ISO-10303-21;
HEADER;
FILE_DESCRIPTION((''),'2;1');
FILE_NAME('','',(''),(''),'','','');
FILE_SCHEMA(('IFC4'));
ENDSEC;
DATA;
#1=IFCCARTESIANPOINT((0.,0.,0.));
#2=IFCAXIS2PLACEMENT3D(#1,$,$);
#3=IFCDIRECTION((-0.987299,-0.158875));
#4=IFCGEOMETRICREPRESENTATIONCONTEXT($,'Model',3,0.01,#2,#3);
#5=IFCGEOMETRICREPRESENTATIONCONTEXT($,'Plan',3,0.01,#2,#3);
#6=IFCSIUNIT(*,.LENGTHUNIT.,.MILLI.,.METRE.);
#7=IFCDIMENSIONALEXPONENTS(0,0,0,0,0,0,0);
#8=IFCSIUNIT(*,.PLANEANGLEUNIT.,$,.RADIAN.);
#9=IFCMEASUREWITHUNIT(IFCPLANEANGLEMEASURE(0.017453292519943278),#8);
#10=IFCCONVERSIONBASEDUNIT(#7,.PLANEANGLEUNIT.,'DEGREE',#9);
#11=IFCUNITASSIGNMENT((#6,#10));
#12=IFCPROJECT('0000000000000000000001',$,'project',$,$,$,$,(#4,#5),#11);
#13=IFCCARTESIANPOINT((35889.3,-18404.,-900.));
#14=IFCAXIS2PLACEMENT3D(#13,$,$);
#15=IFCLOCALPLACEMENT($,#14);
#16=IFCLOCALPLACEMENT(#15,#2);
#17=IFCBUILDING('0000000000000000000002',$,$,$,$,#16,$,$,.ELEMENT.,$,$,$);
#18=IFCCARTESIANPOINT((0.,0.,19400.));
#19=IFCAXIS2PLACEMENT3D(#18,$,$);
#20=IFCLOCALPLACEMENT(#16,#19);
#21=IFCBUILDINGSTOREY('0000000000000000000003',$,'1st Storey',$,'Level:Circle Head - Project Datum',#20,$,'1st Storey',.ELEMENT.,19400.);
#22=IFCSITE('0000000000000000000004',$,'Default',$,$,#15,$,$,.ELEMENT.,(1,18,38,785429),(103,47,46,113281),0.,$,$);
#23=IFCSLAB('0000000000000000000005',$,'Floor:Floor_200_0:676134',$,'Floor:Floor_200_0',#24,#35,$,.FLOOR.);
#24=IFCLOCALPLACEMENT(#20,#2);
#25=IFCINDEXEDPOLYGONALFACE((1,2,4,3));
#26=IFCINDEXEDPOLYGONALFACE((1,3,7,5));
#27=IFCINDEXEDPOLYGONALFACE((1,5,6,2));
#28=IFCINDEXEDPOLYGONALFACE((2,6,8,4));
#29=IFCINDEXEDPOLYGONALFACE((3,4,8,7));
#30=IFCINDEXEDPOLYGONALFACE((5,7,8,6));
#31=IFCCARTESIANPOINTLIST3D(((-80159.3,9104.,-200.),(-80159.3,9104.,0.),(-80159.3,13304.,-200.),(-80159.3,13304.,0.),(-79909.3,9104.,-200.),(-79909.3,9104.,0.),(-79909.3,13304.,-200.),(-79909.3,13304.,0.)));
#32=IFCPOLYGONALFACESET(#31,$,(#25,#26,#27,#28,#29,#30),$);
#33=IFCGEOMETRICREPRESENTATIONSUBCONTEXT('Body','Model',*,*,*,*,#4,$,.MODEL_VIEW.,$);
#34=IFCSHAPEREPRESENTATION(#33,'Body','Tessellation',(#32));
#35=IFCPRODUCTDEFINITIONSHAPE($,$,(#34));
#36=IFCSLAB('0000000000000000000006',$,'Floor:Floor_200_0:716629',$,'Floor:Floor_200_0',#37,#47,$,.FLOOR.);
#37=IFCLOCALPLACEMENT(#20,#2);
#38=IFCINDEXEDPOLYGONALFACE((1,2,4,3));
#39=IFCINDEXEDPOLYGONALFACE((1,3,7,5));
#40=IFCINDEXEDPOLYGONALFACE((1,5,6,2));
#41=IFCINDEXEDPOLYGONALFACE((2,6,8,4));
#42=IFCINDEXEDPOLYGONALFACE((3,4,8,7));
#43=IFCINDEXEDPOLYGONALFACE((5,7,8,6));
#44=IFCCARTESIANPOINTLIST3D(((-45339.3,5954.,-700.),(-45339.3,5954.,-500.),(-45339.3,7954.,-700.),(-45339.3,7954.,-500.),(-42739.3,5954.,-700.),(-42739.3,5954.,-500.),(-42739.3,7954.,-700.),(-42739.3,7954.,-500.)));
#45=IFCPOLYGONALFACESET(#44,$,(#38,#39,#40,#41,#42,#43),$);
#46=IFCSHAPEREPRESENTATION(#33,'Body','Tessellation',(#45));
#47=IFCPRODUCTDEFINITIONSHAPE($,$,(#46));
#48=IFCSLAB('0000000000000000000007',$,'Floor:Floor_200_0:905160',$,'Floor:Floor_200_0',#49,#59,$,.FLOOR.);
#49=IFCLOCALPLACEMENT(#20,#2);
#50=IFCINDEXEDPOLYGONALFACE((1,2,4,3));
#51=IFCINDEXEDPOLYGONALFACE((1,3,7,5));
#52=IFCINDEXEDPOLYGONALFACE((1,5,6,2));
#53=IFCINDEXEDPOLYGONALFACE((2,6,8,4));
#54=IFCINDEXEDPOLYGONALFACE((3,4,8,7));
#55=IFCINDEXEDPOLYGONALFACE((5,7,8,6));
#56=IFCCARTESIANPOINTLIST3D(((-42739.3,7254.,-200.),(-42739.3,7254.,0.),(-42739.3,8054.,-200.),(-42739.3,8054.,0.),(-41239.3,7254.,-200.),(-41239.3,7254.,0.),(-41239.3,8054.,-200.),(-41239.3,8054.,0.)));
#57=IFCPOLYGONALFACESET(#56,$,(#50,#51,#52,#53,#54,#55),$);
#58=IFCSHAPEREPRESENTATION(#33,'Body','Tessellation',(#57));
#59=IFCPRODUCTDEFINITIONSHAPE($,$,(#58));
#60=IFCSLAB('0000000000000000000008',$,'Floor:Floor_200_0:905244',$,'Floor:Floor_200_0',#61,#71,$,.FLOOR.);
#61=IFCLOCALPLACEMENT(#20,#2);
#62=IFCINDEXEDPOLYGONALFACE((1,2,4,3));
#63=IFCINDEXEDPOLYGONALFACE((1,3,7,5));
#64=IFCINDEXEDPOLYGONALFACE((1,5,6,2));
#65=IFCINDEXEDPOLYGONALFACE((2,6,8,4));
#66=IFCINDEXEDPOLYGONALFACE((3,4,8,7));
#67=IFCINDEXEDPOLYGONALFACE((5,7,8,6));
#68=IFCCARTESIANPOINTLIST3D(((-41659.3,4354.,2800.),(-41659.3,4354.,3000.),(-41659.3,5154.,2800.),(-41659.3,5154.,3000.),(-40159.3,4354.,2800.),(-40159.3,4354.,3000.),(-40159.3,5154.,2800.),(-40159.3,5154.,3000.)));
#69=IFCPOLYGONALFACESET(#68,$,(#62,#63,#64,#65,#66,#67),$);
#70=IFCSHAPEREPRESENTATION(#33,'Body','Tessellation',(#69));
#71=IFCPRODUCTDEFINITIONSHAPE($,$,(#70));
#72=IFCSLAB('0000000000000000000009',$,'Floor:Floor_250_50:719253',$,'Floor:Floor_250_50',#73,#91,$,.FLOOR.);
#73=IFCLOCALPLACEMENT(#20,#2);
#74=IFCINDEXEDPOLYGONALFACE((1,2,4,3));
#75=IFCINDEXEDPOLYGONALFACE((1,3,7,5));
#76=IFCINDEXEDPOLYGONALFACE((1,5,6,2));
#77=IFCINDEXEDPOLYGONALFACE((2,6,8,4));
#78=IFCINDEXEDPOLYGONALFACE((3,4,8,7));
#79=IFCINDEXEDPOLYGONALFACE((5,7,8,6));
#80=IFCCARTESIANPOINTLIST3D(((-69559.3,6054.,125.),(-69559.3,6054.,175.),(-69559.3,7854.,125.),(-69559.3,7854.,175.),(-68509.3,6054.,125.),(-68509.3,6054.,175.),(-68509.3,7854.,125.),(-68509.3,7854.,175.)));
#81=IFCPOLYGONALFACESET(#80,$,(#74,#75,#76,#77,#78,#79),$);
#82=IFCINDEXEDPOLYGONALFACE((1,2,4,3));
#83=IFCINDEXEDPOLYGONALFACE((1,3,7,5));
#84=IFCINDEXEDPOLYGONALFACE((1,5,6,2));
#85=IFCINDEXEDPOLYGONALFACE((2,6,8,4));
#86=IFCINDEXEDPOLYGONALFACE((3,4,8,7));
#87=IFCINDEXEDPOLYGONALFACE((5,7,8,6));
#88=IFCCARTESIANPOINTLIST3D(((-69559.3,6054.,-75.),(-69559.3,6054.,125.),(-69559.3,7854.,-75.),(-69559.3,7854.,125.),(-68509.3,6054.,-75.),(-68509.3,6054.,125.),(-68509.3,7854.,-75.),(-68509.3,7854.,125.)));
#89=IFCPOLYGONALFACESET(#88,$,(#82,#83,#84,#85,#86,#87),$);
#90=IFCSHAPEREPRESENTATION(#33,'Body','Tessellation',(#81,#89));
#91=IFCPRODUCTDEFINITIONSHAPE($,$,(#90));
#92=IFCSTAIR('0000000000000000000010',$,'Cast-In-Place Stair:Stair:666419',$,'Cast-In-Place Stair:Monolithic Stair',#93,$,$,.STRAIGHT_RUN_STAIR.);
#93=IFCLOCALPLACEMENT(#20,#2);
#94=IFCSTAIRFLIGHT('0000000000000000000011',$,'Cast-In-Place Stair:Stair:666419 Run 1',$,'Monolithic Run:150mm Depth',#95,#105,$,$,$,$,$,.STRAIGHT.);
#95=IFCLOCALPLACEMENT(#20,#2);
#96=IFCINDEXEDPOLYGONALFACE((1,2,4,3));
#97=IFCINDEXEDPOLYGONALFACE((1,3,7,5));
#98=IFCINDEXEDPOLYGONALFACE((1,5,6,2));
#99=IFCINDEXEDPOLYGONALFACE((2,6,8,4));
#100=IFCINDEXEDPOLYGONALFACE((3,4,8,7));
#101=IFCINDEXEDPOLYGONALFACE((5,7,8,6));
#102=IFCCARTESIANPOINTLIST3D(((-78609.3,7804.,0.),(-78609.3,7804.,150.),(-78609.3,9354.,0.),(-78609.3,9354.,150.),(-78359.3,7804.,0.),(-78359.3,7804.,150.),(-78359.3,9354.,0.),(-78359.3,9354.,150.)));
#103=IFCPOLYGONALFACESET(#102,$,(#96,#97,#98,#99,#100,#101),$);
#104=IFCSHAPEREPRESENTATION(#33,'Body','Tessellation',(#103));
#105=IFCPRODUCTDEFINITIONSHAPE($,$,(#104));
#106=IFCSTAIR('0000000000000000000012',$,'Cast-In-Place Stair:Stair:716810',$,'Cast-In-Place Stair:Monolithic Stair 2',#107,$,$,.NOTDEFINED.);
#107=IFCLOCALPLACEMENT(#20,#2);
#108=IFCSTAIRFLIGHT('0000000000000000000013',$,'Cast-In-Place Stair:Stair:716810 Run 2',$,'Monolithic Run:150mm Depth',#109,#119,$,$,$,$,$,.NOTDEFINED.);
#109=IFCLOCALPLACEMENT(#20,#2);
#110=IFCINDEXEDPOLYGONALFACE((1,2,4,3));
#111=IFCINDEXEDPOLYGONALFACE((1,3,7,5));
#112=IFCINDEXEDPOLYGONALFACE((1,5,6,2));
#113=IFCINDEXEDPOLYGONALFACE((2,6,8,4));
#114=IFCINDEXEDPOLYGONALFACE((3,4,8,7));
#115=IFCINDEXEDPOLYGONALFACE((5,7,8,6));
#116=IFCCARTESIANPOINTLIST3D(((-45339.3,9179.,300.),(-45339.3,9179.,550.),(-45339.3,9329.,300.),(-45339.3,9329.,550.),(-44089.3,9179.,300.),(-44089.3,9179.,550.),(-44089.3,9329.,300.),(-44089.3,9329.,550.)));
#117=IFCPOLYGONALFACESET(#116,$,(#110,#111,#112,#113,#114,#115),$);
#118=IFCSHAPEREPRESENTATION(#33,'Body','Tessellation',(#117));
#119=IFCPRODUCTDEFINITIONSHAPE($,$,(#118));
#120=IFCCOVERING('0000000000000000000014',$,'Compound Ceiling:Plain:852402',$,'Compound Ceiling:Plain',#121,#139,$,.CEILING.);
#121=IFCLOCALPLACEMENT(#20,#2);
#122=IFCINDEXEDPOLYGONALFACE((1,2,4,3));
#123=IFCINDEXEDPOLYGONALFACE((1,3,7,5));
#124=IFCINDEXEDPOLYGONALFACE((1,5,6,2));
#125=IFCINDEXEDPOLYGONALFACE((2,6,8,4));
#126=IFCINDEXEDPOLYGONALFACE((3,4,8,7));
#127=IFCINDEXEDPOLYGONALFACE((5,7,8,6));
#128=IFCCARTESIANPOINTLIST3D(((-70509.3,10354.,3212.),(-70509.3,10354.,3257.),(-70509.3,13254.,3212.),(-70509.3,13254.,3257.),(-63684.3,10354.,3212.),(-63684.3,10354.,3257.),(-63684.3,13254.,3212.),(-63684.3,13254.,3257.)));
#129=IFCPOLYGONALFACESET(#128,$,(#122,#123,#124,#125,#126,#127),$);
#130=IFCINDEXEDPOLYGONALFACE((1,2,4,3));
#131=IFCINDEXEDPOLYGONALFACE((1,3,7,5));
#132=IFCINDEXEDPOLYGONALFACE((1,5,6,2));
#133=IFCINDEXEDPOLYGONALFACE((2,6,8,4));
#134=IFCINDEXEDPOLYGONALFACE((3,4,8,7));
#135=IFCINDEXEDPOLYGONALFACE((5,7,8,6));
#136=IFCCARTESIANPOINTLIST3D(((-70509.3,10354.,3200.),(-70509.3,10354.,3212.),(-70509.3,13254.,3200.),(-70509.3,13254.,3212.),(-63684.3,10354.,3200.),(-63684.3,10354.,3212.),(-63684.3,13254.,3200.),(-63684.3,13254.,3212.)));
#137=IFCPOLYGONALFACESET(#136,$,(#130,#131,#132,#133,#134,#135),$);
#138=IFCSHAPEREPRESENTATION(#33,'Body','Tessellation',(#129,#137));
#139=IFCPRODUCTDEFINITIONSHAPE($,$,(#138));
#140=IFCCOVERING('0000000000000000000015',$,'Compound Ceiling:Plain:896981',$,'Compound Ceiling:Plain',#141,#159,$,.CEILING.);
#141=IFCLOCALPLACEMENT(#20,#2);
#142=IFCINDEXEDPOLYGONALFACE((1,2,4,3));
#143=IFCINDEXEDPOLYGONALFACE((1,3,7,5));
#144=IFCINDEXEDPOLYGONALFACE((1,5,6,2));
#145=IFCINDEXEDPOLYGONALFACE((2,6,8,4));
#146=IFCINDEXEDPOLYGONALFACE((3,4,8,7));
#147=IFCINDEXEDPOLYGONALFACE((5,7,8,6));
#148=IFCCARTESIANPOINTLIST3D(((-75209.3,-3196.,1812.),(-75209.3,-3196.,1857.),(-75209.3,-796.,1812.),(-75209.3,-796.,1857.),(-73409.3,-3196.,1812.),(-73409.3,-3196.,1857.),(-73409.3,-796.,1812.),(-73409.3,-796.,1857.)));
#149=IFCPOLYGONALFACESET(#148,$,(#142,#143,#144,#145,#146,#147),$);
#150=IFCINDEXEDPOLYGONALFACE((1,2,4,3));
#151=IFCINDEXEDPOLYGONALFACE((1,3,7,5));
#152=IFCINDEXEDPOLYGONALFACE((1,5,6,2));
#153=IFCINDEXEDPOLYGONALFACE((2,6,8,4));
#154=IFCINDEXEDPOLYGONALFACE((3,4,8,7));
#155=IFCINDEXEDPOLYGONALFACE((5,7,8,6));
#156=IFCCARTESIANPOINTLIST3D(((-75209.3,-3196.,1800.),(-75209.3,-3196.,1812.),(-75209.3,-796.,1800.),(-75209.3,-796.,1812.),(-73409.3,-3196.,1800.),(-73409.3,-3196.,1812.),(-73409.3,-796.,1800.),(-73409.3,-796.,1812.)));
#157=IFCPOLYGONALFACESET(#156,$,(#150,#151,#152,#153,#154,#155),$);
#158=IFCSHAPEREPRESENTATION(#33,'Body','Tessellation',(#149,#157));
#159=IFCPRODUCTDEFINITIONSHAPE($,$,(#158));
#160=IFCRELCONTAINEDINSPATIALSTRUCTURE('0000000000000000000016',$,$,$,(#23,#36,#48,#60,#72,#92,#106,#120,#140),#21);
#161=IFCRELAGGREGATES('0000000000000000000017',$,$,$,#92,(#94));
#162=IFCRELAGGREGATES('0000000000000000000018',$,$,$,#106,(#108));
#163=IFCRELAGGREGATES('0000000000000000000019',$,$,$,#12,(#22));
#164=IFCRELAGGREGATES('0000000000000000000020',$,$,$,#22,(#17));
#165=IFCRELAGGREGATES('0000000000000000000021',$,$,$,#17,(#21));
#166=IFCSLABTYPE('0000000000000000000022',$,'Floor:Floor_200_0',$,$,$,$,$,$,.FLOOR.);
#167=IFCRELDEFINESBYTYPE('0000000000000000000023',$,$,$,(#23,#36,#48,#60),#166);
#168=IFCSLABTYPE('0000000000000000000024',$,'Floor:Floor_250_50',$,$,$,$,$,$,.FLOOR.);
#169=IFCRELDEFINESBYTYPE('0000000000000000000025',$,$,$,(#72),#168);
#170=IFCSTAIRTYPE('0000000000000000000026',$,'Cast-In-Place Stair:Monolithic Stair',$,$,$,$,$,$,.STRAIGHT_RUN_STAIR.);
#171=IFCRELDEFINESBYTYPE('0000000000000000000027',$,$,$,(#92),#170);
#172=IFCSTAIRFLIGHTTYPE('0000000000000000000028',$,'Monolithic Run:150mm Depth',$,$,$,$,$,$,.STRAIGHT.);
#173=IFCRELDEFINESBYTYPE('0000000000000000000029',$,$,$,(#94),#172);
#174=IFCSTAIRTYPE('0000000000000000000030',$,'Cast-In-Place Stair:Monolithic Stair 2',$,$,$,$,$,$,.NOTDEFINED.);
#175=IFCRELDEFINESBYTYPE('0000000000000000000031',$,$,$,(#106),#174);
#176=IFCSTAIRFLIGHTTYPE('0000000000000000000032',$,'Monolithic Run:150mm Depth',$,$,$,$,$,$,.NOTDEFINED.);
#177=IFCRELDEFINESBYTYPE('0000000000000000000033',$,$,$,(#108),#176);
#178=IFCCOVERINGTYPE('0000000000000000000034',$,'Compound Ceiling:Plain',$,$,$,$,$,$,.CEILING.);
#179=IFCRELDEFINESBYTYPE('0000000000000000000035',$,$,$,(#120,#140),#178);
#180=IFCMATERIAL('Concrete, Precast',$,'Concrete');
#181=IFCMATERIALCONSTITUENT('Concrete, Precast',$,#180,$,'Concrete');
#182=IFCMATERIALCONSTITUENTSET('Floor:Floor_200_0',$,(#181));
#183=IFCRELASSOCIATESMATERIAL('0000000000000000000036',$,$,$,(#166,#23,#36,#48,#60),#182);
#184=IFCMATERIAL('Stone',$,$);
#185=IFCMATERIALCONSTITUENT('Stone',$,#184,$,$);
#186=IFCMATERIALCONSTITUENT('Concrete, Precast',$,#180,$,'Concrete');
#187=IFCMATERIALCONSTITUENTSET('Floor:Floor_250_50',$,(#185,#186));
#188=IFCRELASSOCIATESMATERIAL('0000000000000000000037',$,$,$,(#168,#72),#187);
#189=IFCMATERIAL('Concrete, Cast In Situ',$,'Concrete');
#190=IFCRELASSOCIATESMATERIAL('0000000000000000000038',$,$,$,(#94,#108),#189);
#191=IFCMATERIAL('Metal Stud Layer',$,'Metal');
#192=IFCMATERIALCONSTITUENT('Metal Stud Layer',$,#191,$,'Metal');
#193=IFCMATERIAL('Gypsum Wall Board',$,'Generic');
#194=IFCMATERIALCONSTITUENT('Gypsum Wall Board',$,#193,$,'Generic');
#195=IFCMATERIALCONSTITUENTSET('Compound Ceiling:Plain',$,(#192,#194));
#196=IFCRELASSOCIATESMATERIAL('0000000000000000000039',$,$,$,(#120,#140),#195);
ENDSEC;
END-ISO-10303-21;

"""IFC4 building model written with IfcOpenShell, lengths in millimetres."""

from ifc_helpers import new_model, entity, si_unit, converted_unit, direction, frame, origin, place, context, subcontext, project, spatial, indexed_curve, outline, extrude, material, constituent, constituent_set, type_object, element, aggregate, save


model = new_model("IFC4")

# Units and contexts
model_context = context("Model", 3, precision=0.01, world=origin(), true_north=direction((-0.987299, -0.158875)))
plan_context = context("Plan", 3, precision=0.01, world=origin(), true_north=direction((-0.987299, -0.158875)))
body_context = subcontext(model_context, "Body", "Model", "MODEL_VIEW")
ifc_project = project(units=[si_unit("LENGTHUNIT", "METRE", prefix="MILLI"), converted_unit("PLANEANGLEUNIT", "DEGREE", entity("IfcPlaneAngleMeasure", 0.017453292519943278), si_unit("PLANEANGLEUNIT", "RADIAN"), dimensions=[0, 0, 0, 0, 0, 0, 0])], contexts=[model_context, plan_context])

# Site, building, storey
site_placement = place(None, frame((35889.3, -18404.0, -900.0)))
site = spatial("IfcSite", under=ifc_project, at=site_placement, Name="Default", CompositionType="ELEMENT", RefLatitude=(1, 18, 38, 785429), RefLongitude=(103, 47, 46, 113281), RefElevation=0.0)
building_placement = place(site_placement, origin())
building = spatial("IfcBuilding", under=site, at=building_placement, CompositionType="ELEMENT")
storey_placement = place(building_placement, frame((0.0, 0.0, 19400.0)))
storey = spatial("IfcBuildingStorey", under=building, at=storey_placement, Name="1st Storey", ObjectType="Level:Circle Head - Project Datum", LongName="1st Storey", CompositionType="ELEMENT", Elevation=19400.0)

# Slabs
ifc_material_1 = material(Name="Concrete, Precast", Category="Concrete")
ifc_constituent_1 = constituent(ifc_material_1, Name="Concrete, Precast", Category="Concrete")
ifc_constituent_set_1 = constituent_set(constituents=[ifc_constituent_1], Name="Floor:Floor_200_0")
slab_type_1 = type_object("IfcSlabType", Name="Floor:Floor_200_0", PredefinedType="FLOOR", material=ifc_constituent_set_1)
slab_1_placement = place(storey_placement, origin())
element("IfcSlab", 1, at=slab_1_placement, inside=storey, type_object=slab_type_1, material=ifc_constituent_set_1, Name="Floor:Floor_200_0:676134", ObjectType="Floor:Floor_200_0", PredefinedType="FLOOR", context=body_context, shape_type="SweptSolid", body=[
    extrude(outline(indexed_curve([(-2100.0, -125.0), (2100.0, -125.0), (2100.0, 125.0), (-2100.0, 125.0), (-2100.0, -125.0)], self_intersect=False)), frame((-80034.3, 11204.0, 0.0), z_axis=(0.0, 0.0, -1.0), x_axis=(0.0, 1.0, 0.0)), (0.0, 0.0, 1.0), 200.0),
])
slab_2_placement = place(storey_placement, origin())
element("IfcSlab", 2, at=slab_2_placement, inside=storey, type_object=slab_type_1, material=ifc_constituent_set_1, Name="Floor:Floor_200_0:716629", ObjectType="Floor:Floor_200_0", PredefinedType="FLOOR", context=body_context, shape_type="SweptSolid", body=[
    extrude(outline(indexed_curve([(-1000.0, -1300.0), (1000.0, -1300.0), (1000.0, 1300.0), (-1000.0, 1300.0), (-1000.0, -1300.0)], self_intersect=False)), frame((-44039.3, 6954.0, -500.0), z_axis=(0.0, 0.0, -1.0), x_axis=(0.0, 1.0, 0.0)), (0.0, 0.0, 1.0), 200.0),
])
slab_3_placement = place(storey_placement, origin())
element("IfcSlab", 3, at=slab_3_placement, inside=storey, type_object=slab_type_1, material=ifc_constituent_set_1, Name="Floor:Floor_200_0:905160", ObjectType="Floor:Floor_200_0", PredefinedType="FLOOR", context=body_context, shape_type="SweptSolid", body=[
    extrude(outline(indexed_curve([(-400.0, -750.0), (400.0, -750.0), (400.0, 750.0), (-400.0, 750.0), (-400.0, -750.0)], self_intersect=False)), frame((-41989.3, 7654.0, 0.0), z_axis=(0.0, 0.0, -1.0), x_axis=(0.0, 1.0, 0.0)), (0.0, 0.0, 1.0), 200.0),
])
slab_4_placement = place(storey_placement, origin())
element("IfcSlab", 4, at=slab_4_placement, inside=storey, type_object=slab_type_1, material=ifc_constituent_set_1, Name="Floor:Floor_200_0:905244", ObjectType="Floor:Floor_200_0", PredefinedType="FLOOR", context=body_context, shape_type="SweptSolid", body=[
    extrude(outline(indexed_curve([(-400.0, -750.0), (400.0, -750.0), (400.0, 750.0), (-400.0, 750.0), (-400.0, -750.0)], self_intersect=False)), frame((-40909.3, 4754.0, 3000.0), z_axis=(0.0, 0.0, -1.0), x_axis=(0.0, 1.0, 0.0)), (0.0, 0.0, 1.0), 200.0),
])

# Shared definitions
stair_type_1 = type_object("IfcStairType", Name="Cast-In-Place Stair:Monolithic Stair", PredefinedType="STRAIGHT_RUN_STAIR")

# Slab
ifc_material_2 = material(Name="Stone")
ifc_constituent_2 = constituent(ifc_material_2, Name="Stone")
ifc_constituent_3 = constituent(ifc_material_1, Name="Concrete, Precast", Category="Concrete")
ifc_constituent_set_2 = constituent_set(constituents=[ifc_constituent_2, ifc_constituent_3], Name="Floor:Floor_250_50")
slab_type_2 = type_object("IfcSlabType", Name="Floor:Floor_250_50", PredefinedType="FLOOR", material=ifc_constituent_set_2)
slab_5_placement = place(storey_placement, origin())
element("IfcSlab", 5, at=slab_5_placement, inside=storey, type_object=slab_type_2, material=ifc_constituent_set_2, Name="Floor:Floor_250_50:719253", ObjectType="Floor:Floor_250_50", PredefinedType="FLOOR", context=body_context, shape_type="SweptSolid", body=[
    extrude(outline(indexed_curve([(-525.0, -900.0), (525.0, -900.0), (525.0, 900.0), (-525.0, 900.0), (-525.0, -900.0)], self_intersect=False)), frame((-69034.3, 6954.0, 125.0), z_axis=(0.0, 0.0, 1.0), x_axis=(-1.0, 0.0, 0.0)), (0.0, 0.0, 1.0), 50.0),
    extrude(outline(indexed_curve([(-525.0, -900.0), (525.0, -900.0), (525.0, 900.0), (-525.0, 900.0), (-525.0, -900.0)], self_intersect=False)), frame((-69034.3, 6954.0, -75.0), z_axis=(0.0, 0.0, 1.0), x_axis=(-1.0, 0.0, 0.0)), (0.0, 0.0, 1.0), 200.0),
])

# Shared definitions
ifc_material_3 = material(Name="Concrete, Cast In Situ", Category="Concrete")
stair_flight_type_1 = type_object("IfcStairFlightType", Name="Monolithic Run:150mm Depth", PredefinedType="STRAIGHT")

# Stairs, stair flights
stair_1_placement = place(storey_placement, origin())
stair_1 = element("IfcStair", 6, at=stair_1_placement, inside=storey, type_object=stair_type_1, Name="Cast-In-Place Stair:Stair:666419", ObjectType="Cast-In-Place Stair:Monolithic Stair", PredefinedType="STRAIGHT_RUN_STAIR")
stair_flight_1_placement = place(stair_1_placement, origin())
stair_flight_1 = element("IfcStairFlight", 7, at=stair_flight_1_placement, type_object=stair_flight_type_1, material=ifc_material_3, Name="Cast-In-Place Stair:Stair:666419 Run 1", ObjectType="Monolithic Run:150mm Depth", PredefinedType="STRAIGHT", context=body_context, shape_type="SweptSolid", body=[
    extrude(outline(indexed_curve([(-775.0, -125.0), (775.0, -125.0), (775.0, 125.0), (-775.0, 125.0), (-775.0, -125.0)], self_intersect=False)), frame((-78484.3, 8579.0, 0.0), z_axis=(0.0, 0.0, 1.0), x_axis=(0.0, 1.0, 0.0)), (0.0, 0.0, 1.0), 150.0),
])
aggregate(stair_1, [stair_flight_1])
stair_type_2 = type_object("IfcStairType", Name="Cast-In-Place Stair:Monolithic Stair 2", PredefinedType="NOTDEFINED")
stair_2_placement = place(storey_placement, origin())
stair_2 = element("IfcStair", 8, at=stair_2_placement, inside=storey, type_object=stair_type_2, Name="Cast-In-Place Stair:Stair:716810", ObjectType="Cast-In-Place Stair:Monolithic Stair 2", PredefinedType="NOTDEFINED")
stair_flight_type_2 = type_object("IfcStairFlightType", Name="Monolithic Run:150mm Depth", PredefinedType="NOTDEFINED")
stair_flight_2_placement = place(stair_2_placement, origin())
stair_flight_2 = element("IfcStairFlight", 9, at=stair_flight_2_placement, type_object=stair_flight_type_2, material=ifc_material_3, Name="Cast-In-Place Stair:Stair:716810 Run 2", ObjectType="Monolithic Run:150mm Depth", PredefinedType="NOTDEFINED", context=body_context, shape_type="SweptSolid", body=[
    extrude(outline(indexed_curve([(-625.0, -75.0), (625.0, -75.0), (625.0, 75.0), (-625.0, 75.0), (-625.0, -75.0)], self_intersect=False)), frame((-44714.3, 9254.0, 300.0)), (0.0, 0.0, 1.0), 250.0),
])
aggregate(stair_2, [stair_flight_2])

# Coverings
ifc_material_4 = material(Name="Metal Stud Layer", Category="Metal")
ifc_constituent_4 = constituent(ifc_material_4, Name="Metal Stud Layer", Category="Metal")
ifc_material_5 = material(Name="Gypsum Wall Board", Category="Generic")
ifc_constituent_5 = constituent(ifc_material_5, Name="Gypsum Wall Board", Category="Generic")
ifc_constituent_set_3 = constituent_set(constituents=[ifc_constituent_4, ifc_constituent_5], Name="Compound Ceiling:Plain")
covering_type = type_object("IfcCoveringType", Name="Compound Ceiling:Plain", PredefinedType="CEILING")
covering_1_placement = place(storey_placement, origin())
element("IfcCovering", 10, at=covering_1_placement, inside=storey, type_object=covering_type, material=ifc_constituent_set_3, Name="Compound Ceiling:Plain:852402", ObjectType="Compound Ceiling:Plain", PredefinedType="CEILING", context=body_context, shape_type="SweptSolid", body=[
    extrude(outline(indexed_curve([(-1450.0, -3412.5), (1450.0, -3412.5), (1450.0, 3412.5), (-1450.0, 3412.5), (-1450.0, -3412.5)], self_intersect=False)), frame((-67096.8, 11804.0, 3212.0), z_axis=(0.0, 0.0, 1.0), x_axis=(0.0, -1.0, 0.0)), (0.0, 0.0, 1.0), 45.0),
    extrude(outline(indexed_curve([(-3412.5, -1450.0), (3412.5, -1450.0), (3412.5, 1450.0), (-3412.5, 1450.0), (-3412.5, -1450.0)], self_intersect=False)), frame((-67096.8, 11804.0, 3200.0), z_axis=(0.0, 0.0, 1.0), x_axis=(-1.0, 0.0, 0.0)), (0.0, 0.0, 1.0), 12.0),
])
covering_2_placement = place(storey_placement, origin())
element("IfcCovering", 11, at=covering_2_placement, inside=storey, type_object=covering_type, material=ifc_constituent_set_3, Name="Compound Ceiling:Plain:896981", ObjectType="Compound Ceiling:Plain", PredefinedType="CEILING", context=body_context, shape_type="SweptSolid", body=[
    extrude(outline(indexed_curve([(-1200.0, -900.0), (1200.0, -900.0), (1200.0, 900.0), (-1200.0, 900.0), (-1200.0, -900.0)], self_intersect=False)), frame((-74309.3, -1996.0, 1812.0), z_axis=(0.0, 0.0, 1.0), x_axis=(0.0, -1.0, 0.0)), (0.0, 0.0, 1.0), 45.0),
    extrude(outline(indexed_curve([(-900.0, -1200.0), (900.0, -1200.0), (900.0, 1200.0), (-900.0, 1200.0), (-900.0, -1200.0)], self_intersect=False)), frame((-74309.3, -1996.0, 1800.0), z_axis=(0.0, 0.0, 1.0), x_axis=(-1.0, 0.0, 0.0)), (0.0, 0.0, 1.0), 12.0),
])

save(model, "model.ifc")
